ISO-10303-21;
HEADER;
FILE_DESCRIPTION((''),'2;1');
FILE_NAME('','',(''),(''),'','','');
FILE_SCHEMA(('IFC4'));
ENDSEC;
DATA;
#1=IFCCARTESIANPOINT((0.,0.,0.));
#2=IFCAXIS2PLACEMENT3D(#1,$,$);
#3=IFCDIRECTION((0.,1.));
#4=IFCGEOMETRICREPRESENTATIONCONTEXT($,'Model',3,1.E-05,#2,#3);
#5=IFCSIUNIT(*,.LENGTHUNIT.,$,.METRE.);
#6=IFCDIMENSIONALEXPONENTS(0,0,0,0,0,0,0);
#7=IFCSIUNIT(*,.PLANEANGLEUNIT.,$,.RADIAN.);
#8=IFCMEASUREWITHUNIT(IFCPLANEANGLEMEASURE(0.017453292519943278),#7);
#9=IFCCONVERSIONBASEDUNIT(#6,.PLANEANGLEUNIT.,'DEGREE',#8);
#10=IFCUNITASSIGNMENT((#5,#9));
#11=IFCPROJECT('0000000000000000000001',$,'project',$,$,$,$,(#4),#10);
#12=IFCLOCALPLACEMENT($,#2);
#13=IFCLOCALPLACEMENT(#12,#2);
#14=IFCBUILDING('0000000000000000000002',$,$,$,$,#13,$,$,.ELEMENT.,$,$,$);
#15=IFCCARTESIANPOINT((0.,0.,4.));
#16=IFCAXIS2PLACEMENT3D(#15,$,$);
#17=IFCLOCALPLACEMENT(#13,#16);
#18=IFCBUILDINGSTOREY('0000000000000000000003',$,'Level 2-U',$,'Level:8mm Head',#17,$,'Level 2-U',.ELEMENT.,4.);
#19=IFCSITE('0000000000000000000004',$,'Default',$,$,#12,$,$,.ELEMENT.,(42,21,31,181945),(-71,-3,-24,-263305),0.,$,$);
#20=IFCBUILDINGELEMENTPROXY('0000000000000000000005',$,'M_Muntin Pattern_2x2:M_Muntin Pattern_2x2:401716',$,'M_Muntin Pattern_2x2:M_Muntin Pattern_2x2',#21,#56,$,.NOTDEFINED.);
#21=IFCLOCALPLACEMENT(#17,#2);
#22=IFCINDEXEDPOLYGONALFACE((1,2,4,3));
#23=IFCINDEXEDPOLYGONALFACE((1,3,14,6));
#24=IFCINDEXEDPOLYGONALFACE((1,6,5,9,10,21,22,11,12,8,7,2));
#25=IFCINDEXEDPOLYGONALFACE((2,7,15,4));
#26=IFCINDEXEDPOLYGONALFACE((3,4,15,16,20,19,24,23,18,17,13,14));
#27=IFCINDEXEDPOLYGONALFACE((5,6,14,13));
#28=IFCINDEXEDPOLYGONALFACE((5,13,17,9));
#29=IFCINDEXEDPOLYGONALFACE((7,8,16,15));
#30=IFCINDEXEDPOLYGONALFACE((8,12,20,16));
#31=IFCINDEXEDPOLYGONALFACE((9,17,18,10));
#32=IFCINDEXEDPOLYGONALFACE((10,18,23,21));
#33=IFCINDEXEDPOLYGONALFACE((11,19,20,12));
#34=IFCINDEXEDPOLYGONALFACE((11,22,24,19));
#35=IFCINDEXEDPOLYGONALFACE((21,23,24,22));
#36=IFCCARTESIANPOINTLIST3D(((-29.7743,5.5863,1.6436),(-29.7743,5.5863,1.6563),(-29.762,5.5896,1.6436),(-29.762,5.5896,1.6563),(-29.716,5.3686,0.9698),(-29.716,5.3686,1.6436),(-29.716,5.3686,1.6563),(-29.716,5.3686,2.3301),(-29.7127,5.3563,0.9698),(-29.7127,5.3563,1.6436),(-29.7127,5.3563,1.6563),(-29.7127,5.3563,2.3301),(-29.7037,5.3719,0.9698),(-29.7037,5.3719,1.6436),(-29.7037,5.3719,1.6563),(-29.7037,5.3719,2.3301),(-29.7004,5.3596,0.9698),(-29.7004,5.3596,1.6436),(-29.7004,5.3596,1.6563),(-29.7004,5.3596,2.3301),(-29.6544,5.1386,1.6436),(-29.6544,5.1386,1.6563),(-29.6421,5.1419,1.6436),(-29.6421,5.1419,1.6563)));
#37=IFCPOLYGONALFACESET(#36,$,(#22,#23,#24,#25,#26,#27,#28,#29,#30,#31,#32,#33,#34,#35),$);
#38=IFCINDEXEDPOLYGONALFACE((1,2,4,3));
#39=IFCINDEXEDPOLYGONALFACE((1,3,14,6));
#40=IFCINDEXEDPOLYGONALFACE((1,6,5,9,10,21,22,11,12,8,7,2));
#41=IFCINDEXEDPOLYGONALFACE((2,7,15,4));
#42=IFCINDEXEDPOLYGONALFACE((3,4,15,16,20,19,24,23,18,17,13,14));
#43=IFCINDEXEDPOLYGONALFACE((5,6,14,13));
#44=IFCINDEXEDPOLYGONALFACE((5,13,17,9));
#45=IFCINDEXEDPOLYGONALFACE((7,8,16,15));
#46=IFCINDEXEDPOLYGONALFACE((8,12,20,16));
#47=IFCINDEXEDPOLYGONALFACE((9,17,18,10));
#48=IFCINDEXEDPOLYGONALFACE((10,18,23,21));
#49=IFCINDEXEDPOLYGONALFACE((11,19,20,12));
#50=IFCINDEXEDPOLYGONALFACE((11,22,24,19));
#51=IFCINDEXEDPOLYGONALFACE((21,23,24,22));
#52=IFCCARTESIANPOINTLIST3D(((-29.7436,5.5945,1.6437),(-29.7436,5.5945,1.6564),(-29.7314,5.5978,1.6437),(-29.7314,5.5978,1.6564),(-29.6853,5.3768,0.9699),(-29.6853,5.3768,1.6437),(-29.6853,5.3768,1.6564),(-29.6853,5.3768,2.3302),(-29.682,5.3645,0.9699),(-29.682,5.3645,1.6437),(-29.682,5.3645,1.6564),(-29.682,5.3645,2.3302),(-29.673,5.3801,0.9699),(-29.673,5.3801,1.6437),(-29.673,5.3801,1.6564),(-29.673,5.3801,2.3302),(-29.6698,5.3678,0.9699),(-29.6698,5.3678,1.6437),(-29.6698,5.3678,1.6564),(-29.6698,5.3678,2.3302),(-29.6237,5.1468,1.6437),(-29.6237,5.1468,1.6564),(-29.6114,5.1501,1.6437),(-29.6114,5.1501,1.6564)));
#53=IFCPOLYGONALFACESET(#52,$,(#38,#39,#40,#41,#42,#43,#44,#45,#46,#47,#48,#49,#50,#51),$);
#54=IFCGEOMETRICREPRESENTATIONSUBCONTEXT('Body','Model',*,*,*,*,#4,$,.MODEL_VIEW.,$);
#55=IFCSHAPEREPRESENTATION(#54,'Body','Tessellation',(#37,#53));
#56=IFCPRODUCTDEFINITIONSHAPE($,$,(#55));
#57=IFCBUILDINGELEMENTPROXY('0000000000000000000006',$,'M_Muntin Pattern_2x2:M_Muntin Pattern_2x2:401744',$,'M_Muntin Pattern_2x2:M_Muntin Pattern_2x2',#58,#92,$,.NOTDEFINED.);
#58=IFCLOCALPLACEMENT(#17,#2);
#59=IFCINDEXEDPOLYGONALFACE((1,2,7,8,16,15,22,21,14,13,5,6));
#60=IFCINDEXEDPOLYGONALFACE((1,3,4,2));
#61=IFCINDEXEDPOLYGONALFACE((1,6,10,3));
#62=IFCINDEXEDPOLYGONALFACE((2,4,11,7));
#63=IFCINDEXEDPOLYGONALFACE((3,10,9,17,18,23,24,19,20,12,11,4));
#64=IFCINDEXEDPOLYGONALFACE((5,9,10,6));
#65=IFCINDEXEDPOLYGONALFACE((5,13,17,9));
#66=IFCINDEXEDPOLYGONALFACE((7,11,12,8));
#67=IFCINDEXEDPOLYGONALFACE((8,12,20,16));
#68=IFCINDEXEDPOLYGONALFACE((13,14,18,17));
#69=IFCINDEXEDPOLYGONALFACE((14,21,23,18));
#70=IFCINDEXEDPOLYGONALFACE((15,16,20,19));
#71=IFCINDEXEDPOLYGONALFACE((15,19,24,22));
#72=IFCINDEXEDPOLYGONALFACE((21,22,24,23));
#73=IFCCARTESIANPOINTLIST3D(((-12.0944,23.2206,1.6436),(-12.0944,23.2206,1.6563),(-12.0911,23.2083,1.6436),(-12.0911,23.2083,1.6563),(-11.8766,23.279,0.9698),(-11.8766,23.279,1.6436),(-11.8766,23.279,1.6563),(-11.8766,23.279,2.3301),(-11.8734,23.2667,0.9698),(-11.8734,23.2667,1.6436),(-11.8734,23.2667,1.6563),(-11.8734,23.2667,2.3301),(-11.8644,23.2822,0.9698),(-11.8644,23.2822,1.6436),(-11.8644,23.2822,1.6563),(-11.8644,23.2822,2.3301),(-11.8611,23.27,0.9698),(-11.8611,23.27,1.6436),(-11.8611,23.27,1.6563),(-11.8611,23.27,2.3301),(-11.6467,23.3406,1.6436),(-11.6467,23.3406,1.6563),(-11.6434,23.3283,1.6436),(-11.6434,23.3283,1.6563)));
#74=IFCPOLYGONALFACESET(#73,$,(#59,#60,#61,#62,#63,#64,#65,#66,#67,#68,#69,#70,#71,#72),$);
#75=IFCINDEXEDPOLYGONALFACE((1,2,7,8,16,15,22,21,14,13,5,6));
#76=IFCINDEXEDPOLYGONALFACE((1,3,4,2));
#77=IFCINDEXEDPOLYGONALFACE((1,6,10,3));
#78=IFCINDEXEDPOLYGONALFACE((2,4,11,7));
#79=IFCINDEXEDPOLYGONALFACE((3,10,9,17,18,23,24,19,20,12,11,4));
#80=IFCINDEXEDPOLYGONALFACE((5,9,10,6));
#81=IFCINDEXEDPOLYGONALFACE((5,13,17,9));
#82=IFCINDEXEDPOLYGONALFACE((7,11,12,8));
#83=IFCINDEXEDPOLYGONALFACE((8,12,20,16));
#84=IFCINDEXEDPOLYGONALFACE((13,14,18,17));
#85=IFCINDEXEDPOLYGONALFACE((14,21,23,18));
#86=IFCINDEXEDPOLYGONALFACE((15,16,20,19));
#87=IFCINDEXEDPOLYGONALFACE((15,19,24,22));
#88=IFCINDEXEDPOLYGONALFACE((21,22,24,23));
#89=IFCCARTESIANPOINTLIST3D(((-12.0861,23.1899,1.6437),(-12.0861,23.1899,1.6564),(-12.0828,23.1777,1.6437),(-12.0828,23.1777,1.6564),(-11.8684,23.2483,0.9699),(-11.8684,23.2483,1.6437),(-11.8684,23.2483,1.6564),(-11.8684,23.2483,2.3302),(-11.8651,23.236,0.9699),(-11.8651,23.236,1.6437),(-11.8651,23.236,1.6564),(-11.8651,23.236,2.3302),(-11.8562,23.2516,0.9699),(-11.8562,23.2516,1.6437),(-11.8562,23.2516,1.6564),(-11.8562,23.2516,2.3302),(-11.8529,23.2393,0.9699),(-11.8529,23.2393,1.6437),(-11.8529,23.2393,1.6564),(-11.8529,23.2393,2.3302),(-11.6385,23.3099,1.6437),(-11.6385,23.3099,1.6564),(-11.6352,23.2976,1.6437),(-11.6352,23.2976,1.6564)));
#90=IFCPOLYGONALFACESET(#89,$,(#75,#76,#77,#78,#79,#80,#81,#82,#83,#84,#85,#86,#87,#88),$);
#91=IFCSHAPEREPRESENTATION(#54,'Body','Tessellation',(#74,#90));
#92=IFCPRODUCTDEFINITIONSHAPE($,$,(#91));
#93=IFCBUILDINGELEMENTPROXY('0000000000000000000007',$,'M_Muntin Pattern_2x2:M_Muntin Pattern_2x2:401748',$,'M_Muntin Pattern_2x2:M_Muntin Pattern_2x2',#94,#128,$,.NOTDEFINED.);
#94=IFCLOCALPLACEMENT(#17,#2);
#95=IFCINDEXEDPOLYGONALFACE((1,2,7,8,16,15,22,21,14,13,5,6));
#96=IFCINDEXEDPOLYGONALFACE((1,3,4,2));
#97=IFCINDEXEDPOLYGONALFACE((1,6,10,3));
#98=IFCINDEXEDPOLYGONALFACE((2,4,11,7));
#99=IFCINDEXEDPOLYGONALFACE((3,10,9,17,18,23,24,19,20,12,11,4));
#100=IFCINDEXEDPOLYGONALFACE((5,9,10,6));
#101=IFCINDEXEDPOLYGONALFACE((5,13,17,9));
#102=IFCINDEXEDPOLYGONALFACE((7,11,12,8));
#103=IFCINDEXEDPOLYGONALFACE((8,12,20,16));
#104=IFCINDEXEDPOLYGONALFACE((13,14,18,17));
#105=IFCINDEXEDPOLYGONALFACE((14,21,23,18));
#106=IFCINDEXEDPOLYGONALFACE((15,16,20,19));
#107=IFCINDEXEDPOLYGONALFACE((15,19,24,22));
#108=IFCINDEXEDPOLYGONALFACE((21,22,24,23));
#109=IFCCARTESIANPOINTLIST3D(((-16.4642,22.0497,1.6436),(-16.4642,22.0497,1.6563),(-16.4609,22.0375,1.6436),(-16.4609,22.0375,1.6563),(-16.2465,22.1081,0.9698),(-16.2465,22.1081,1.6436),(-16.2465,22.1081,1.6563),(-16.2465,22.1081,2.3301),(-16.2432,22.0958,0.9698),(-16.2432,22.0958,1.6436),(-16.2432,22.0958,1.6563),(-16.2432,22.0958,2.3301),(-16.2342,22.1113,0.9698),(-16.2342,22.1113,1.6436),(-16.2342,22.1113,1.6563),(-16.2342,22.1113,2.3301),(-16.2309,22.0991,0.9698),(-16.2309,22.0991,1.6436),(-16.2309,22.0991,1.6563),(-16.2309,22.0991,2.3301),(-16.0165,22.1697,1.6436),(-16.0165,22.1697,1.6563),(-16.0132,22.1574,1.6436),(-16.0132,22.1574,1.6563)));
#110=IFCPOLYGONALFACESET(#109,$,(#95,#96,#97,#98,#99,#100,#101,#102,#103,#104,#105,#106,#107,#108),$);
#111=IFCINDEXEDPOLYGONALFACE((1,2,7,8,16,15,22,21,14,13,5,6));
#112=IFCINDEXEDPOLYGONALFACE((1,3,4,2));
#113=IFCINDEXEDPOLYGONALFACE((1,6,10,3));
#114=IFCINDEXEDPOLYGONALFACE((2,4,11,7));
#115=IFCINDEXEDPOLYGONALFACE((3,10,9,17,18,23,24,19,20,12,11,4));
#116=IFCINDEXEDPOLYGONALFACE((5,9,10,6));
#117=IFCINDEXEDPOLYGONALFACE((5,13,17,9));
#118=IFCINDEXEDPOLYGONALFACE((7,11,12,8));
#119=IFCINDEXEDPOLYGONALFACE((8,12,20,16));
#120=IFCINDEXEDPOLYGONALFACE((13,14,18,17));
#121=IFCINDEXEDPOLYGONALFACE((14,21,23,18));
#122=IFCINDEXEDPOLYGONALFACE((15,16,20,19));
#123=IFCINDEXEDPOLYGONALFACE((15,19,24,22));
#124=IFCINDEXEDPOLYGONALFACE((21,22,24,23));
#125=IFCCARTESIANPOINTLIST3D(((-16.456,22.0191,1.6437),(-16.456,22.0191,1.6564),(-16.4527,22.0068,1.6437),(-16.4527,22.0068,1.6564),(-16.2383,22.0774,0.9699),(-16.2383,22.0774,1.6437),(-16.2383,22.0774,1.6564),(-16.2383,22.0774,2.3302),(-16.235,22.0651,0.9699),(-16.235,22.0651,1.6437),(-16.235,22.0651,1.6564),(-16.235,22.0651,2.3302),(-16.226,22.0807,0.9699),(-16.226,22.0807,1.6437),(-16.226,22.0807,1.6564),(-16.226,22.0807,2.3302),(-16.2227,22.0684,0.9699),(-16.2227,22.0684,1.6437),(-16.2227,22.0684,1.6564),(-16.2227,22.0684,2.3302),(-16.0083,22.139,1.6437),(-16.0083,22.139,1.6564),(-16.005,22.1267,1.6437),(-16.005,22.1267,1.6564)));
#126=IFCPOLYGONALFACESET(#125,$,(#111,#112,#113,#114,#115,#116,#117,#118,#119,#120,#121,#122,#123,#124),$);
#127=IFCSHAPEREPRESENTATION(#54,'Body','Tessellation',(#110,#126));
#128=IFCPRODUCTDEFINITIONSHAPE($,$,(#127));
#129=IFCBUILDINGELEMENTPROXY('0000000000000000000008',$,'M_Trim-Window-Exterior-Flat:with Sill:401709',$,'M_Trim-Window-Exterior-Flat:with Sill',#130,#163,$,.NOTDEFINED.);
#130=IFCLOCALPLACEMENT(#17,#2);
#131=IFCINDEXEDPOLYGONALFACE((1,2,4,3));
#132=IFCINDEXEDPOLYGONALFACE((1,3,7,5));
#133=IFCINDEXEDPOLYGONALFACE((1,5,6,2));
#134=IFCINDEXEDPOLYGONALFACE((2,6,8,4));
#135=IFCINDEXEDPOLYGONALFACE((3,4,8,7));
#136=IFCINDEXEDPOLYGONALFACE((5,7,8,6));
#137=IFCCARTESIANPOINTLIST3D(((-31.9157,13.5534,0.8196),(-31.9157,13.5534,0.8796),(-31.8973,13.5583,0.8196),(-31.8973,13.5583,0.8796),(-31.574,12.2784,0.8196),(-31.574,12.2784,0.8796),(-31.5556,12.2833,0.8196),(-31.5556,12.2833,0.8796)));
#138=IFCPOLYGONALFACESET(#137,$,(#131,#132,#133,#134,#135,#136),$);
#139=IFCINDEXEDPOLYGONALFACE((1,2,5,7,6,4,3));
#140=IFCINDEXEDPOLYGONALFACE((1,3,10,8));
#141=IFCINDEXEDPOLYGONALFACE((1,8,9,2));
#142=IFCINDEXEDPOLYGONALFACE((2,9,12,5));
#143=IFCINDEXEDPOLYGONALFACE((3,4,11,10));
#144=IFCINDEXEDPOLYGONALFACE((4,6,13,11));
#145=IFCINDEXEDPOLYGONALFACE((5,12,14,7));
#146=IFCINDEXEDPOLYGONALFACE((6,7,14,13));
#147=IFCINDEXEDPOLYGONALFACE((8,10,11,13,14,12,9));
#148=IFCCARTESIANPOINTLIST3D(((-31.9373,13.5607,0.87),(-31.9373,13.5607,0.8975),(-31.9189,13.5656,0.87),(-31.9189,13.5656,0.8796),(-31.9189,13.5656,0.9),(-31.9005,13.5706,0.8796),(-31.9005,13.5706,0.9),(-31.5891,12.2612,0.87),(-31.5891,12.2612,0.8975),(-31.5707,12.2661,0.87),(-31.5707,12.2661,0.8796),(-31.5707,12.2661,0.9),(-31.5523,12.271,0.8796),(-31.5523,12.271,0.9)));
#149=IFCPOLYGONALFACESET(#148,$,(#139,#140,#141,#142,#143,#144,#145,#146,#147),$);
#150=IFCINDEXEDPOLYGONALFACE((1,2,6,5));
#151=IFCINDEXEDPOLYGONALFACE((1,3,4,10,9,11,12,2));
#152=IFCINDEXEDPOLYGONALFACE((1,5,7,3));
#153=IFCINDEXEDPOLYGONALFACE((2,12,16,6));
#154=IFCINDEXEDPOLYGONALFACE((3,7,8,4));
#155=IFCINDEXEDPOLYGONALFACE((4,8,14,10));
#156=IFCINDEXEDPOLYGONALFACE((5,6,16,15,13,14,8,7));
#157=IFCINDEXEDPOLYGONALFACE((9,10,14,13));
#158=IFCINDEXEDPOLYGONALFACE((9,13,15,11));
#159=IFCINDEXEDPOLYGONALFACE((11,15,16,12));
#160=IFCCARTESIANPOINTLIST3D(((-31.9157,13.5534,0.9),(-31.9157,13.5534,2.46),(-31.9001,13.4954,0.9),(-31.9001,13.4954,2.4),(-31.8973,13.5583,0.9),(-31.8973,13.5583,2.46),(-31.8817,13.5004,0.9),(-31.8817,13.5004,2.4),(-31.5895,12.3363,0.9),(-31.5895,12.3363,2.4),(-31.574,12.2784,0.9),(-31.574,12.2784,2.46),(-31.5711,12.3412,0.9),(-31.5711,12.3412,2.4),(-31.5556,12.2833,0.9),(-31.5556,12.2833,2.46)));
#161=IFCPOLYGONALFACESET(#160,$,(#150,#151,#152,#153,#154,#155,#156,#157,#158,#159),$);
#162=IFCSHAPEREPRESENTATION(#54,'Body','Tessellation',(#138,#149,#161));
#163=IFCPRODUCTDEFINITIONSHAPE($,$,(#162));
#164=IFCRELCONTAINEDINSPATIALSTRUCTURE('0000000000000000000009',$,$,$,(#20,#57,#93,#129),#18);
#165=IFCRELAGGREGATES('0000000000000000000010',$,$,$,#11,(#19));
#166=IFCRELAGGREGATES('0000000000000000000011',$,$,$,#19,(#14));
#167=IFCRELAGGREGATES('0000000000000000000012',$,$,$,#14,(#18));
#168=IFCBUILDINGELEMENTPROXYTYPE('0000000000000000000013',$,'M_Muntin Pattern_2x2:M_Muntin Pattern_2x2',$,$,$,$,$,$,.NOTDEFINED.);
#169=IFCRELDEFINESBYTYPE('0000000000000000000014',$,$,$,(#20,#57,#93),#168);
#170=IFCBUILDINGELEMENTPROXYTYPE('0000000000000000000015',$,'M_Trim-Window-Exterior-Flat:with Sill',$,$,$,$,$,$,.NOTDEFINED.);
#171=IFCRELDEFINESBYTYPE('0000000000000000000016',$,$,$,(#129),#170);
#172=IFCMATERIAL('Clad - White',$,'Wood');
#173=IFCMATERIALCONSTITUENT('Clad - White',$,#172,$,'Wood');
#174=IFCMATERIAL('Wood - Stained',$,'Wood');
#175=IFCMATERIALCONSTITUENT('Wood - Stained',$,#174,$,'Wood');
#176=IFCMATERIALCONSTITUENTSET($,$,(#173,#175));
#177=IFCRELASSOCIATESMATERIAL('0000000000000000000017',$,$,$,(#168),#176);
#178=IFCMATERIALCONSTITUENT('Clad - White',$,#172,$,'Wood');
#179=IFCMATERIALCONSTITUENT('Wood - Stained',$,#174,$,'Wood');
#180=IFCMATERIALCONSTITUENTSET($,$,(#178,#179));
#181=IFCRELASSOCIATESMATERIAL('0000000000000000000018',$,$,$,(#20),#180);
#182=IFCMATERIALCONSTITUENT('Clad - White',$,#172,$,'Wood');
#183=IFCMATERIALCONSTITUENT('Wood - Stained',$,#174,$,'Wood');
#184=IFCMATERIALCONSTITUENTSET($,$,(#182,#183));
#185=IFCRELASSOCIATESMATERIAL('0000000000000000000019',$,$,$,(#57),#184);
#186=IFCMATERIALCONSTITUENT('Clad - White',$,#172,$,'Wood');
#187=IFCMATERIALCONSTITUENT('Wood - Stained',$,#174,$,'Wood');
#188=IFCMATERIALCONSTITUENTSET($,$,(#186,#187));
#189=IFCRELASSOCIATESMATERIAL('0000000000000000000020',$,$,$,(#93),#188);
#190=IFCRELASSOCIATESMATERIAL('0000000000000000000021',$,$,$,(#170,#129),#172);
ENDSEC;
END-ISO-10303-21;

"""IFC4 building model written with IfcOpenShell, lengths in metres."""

from ifc_helpers import new_model, entity, si_unit, converted_unit, direction, frame, frame_2d, origin, place, context, subcontext, project, spatial, polyline, rectangle, outline, extrude, source, transform, mapped, material, constituent, constituent_set, type_object, type_shapes, element, save


model = new_model("IFC4")

# Units and contexts
model_context = context("Model", 3, precision=1e-05, world=origin(), true_north=direction((0.0, 1.0)))
body_context = subcontext(model_context, "Body", "Model", "MODEL_VIEW")
ifc_project = project(units=[si_unit("LENGTHUNIT", "METRE"), converted_unit("PLANEANGLEUNIT", "DEGREE", entity("IfcPlaneAngleMeasure", 0.017453292519943278), si_unit("PLANEANGLEUNIT", "RADIAN"), dimensions=[0, 0, 0, 0, 0, 0, 0])], contexts=[model_context])

# Site, building, storey
site_placement = place(None, origin())
site = spatial("IfcSite", under=ifc_project, at=site_placement, Name="Default", CompositionType="ELEMENT", RefLatitude=(42, 21, 31, 181945), RefLongitude=(-71, -3, -24, -263305), RefElevation=0.0)
building_placement = place(site_placement, origin())
building = spatial("IfcBuilding", under=site, at=building_placement, CompositionType="ELEMENT")
storey_placement = place(building_placement, frame((0.0, 0.0, 4.0)))
storey = spatial("IfcBuildingStorey", under=building, at=storey_placement, Name="Level 2-U", ObjectType="Level:8mm Head", LongName="Level 2-U", CompositionType="ELEMENT", Elevation=4.0)

# Building element proxies
ifc_material_1 = material(Name="Clad - White", Category="Wood")
ifc_material_2 = material(Name="Wood - Stained", Category="Wood")
ifc_constituent_1 = constituent(ifc_material_1, Name="Clad - White", Category="Wood")
ifc_constituent_2 = constituent(ifc_material_2, Name="Wood - Stained", Category="Wood")
ifc_constituent_set_1 = constituent_set(constituents=[ifc_constituent_1, ifc_constituent_2])
building_element_proxy_type_1 = type_object("IfcBuildingElementProxyType", Name="M_Muntin Pattern_2x2:M_Muntin Pattern_2x2", PredefinedType="NOTDEFINED", material=ifc_constituent_set_1)
shared_shape_1 = source(origin(), body_context, "Body", "SweptSolid", [
    extrude(outline(polyline([(0.0064, -0.0064), (0.6801, -0.0064), (0.6801, 0.0063), (0.0064, 0.0063), (0.0064, 0.2317), (-0.0063, 0.2317), (-0.0063, 0.0063), (-0.6802, 0.0063), (-0.6802, -0.0064), (-0.0063, -0.0064), (-0.0063, -0.2317), (0.0064, -0.2317), (0.0064, -0.0064)])), frame((0.0, -0.0222, 0.6801), z_axis=(0.0, 1.0, 0.0), x_axis=(0.0, 0.0, 1.0)), (0.0, 0.0, 1.0), 0.0127),
    extrude(outline(polyline([(0.0064, -0.0064), (0.6802, -0.0064), (0.6802, 0.0063), (0.0064, 0.0063), (0.0064, 0.2317), (-0.0063, 0.2317), (-0.0063, 0.0063), (-0.6802, 0.0063), (-0.6802, -0.0064), (-0.0063, -0.0064), (-0.0063, -0.2317), (0.0064, -0.2317), (0.0064, -0.0064)])), frame((0.0, 0.0095, 0.6802), z_axis=(0.0, 1.0, 0.0), x_axis=(0.0, 0.0, 1.0)), (0.0, 0.0, 1.0), 0.0127),
])
type_shapes(building_element_proxy_type_1, [shared_shape_1])
ifc_constituent_3 = constituent(ifc_material_1, Name="Clad - White", Category="Wood")
ifc_constituent_4 = constituent(ifc_material_2, Name="Wood - Stained", Category="Wood")
ifc_constituent_set_2 = constituent_set(constituents=[ifc_constituent_3, ifc_constituent_4])
proxy_1_placement = place(storey_placement, frame((-29.6929, 5.3682, 0.9699), z_axis=(0.0, 0.0, 1.0), x_axis=(0.258819, -0.965926, 0.0)))
element("IfcBuildingElementProxy", 1, at=proxy_1_placement, inside=storey, type_object=building_element_proxy_type_1, material=ifc_constituent_set_2, Name="M_Muntin Pattern_2x2:M_Muntin Pattern_2x2:401716", ObjectType="M_Muntin Pattern_2x2:M_Muntin Pattern_2x2", PredefinedType="NOTDEFINED", context=body_context, shape_type="MappedRepresentation", body=[
    mapped(shared_shape_1, transform((0.0, 0.0, 0.0), scale=1.0)),
])
ifc_constituent_5 = constituent(ifc_material_1, Name="Clad - White", Category="Wood")
ifc_constituent_6 = constituent(ifc_material_2, Name="Wood - Stained", Category="Wood")
ifc_constituent_set_3 = constituent_set(constituents=[ifc_constituent_5, ifc_constituent_6])
proxy_2_placement = place(storey_placement, frame((-11.8648, 23.2591, 0.9699), z_axis=(0.0, 0.0, 1.0), x_axis=(-0.965926, -0.258819, 0.0)))
element("IfcBuildingElementProxy", 2, at=proxy_2_placement, inside=storey, type_object=building_element_proxy_type_1, material=ifc_constituent_set_3, Name="M_Muntin Pattern_2x2:M_Muntin Pattern_2x2:401744", ObjectType="M_Muntin Pattern_2x2:M_Muntin Pattern_2x2", PredefinedType="NOTDEFINED", context=body_context, shape_type="MappedRepresentation", body=[
    mapped(shared_shape_1, transform((0.0, 0.0, 0.0), scale=1.0)),
])
ifc_constituent_7 = constituent(ifc_material_1, Name="Clad - White", Category="Wood")
ifc_constituent_8 = constituent(ifc_material_2, Name="Wood - Stained", Category="Wood")
ifc_constituent_set_4 = constituent_set(constituents=[ifc_constituent_7, ifc_constituent_8])
proxy_3_placement = place(storey_placement, frame((-16.2346, 22.0882, 0.9699), z_axis=(0.0, 0.0, 1.0), x_axis=(-0.965926, -0.258819, 0.0)))
element("IfcBuildingElementProxy", 3, at=proxy_3_placement, inside=storey, type_object=building_element_proxy_type_1, material=ifc_constituent_set_4, Name="M_Muntin Pattern_2x2:M_Muntin Pattern_2x2:401748", ObjectType="M_Muntin Pattern_2x2:M_Muntin Pattern_2x2", PredefinedType="NOTDEFINED", context=body_context, shape_type="MappedRepresentation", body=[
    mapped(shared_shape_1, transform((0.0, 0.0, 0.0), scale=1.0)),
])
building_element_proxy_type_2 = type_object("IfcBuildingElementProxyType", Name="M_Trim-Window-Exterior-Flat:with Sill", PredefinedType="NOTDEFINED", material=ifc_material_1)
shared_shape_2 = source(origin(), body_context, "Body", "SweptSolid", [
    extrude(rectangle(XDim=1.32, YDim=0.06, at=frame_2d((0.0, 0.0), x_axis=(1.0, 0.0))), frame((0.0, -1.5504, 0.0), z_axis=(0.0, 0.0, 1.0), x_axis=(-1.0, 0.0, 0.0)), (0.0, 0.0, 1.0), 0.019),
    extrude(outline(polyline([(-0.019, -0.0152), (0.0, -0.0152), (0.0, -0.0057), (0.019, -0.0057), (0.019, 0.0148), (0.0, 0.0148), (-0.019, 0.0123), (-0.019, -0.0152)])), frame((-0.6727, -1.5148, 0.019), z_axis=(1.0, 0.0, 0.0), x_axis=(0.0, 0.0, -1.0)), (0.0, 0.0, 1.0), 1.3454),
    extrude(outline(polyline([(-0.795, -0.66), (0.765, -0.66), (0.765, -0.6), (-0.735, -0.6), (-0.735, 0.6), (0.765, 0.6), (0.765, 0.66), (-0.795, 0.66), (-0.795, -0.66)])), frame((0.0, -0.735, 0.0), z_axis=(0.0, 0.0, 1.0), x_axis=(0.0, -1.0, 0.0)), (0.0, 0.0, 1.0), 0.019),
])
type_shapes(building_element_proxy_type_2, [shared_shape_2])
for number, where, z_axis, x_axis, name in (
    (4, (-31.7264, 12.9208, 2.4), (-0.965926, -0.258819, 0.0), (0.258819, -0.965926, 0.0), "M_Trim-Window-Exterior-Flat:with Sill:401709"),
):
    element("IfcBuildingElementProxy", number, at=place(storey_placement, frame(where, z_axis=z_axis, x_axis=x_axis)), inside=storey, type_object=building_element_proxy_type_2, material=ifc_material_1, Name=name, ObjectType="M_Trim-Window-Exterior-Flat:with Sill", PredefinedType="NOTDEFINED", context=body_context, shape_type="MappedRepresentation", body=[
        mapped(shared_shape_2, transform((0.0, 0.0, 0.0), scale=1.0)),
    ])

save(model, "model.ifc")
